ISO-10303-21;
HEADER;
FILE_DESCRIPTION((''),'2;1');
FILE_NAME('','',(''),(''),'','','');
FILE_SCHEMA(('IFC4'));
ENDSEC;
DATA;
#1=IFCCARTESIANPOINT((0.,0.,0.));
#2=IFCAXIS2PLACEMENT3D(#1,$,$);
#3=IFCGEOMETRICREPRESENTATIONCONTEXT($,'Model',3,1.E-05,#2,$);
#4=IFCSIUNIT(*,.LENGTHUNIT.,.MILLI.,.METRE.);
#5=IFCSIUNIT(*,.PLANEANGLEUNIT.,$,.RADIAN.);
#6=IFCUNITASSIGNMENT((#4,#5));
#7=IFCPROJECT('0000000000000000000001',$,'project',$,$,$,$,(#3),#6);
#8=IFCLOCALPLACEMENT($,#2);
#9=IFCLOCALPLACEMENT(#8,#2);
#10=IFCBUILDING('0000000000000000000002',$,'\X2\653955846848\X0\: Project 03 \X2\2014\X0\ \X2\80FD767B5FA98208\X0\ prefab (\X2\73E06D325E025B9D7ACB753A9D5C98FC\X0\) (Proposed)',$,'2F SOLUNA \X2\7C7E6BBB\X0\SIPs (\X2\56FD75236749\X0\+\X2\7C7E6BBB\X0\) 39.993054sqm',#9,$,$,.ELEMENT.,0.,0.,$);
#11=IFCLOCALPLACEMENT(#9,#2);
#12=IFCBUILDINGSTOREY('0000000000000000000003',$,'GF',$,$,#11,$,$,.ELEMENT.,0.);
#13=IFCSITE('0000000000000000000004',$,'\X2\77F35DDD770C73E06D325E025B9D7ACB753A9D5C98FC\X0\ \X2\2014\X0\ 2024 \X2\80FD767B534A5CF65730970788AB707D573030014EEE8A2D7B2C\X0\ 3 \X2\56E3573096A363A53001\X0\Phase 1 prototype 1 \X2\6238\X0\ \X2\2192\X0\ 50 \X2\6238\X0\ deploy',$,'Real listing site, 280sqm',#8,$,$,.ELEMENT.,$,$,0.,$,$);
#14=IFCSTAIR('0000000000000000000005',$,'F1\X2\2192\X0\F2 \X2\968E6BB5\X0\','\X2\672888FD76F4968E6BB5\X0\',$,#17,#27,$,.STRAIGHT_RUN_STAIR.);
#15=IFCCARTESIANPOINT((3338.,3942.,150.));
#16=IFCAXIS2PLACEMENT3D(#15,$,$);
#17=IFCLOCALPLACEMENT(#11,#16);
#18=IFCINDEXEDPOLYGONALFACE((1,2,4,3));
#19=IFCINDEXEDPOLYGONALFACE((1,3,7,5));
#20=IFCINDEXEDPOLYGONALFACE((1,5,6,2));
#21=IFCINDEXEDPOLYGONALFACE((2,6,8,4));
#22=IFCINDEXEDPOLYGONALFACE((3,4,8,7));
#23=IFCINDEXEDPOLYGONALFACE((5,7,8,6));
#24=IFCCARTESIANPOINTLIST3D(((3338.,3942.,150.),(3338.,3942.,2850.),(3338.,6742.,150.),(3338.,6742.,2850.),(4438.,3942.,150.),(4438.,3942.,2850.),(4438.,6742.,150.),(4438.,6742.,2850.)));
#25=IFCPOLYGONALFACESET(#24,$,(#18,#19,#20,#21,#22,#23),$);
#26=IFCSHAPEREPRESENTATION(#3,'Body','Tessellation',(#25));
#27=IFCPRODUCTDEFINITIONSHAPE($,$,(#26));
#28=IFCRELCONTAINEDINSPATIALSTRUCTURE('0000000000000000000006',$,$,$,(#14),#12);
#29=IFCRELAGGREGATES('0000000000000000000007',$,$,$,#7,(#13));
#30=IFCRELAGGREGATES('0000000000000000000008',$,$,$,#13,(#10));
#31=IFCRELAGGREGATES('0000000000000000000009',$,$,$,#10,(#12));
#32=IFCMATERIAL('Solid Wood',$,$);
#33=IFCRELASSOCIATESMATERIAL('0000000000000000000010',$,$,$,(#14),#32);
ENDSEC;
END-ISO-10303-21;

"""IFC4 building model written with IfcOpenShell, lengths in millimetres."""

from ifc_helpers import new_model, si_unit, frame, frame_2d, origin, place, context, project, spatial, rectangle, extrude, material, element, save


model = new_model("IFC4")

# Units and contexts
model_context = context("Model", 3, precision=1e-05, world=origin())
ifc_project = project(units=[si_unit("LENGTHUNIT", "METRE", prefix="MILLI"), si_unit("PLANEANGLEUNIT", "RADIAN")], contexts=[model_context])

# Site, building, storey
site_placement = place(None, origin())
site = spatial("IfcSite", under=ifc_project, at=site_placement, Name="石川県珠洲市宝立町鵜飼 — 2024 能登半島地震被災地、仮設第 3 団地隣接、Phase 1 prototype 1 戸 → 50 戸 deploy", ObjectType="Real listing site, 280sqm", CompositionType="ELEMENT", RefElevation=0.0)
building_placement = place(site_placement, origin())
building = spatial("IfcBuilding", under=site, at=building_placement, Name="改善案: Project 03 — 能登復興 prefab (珠洲市宝立町鵜飼) (Proposed)", ObjectType="2F SOLUNA 籾殻SIPs (国産杉+籾殻) 39.993054sqm", CompositionType="ELEMENT", ElevationOfRefHeight=0.0, ElevationOfTerrain=0.0)
storey_placement = place(building_placement, origin())
storey = spatial("IfcBuildingStorey", under=building, at=storey_placement, Name="GF", CompositionType="ELEMENT", Elevation=0.0)

# Stair
ifc_material_1 = material(Name="Solid Wood")
stair_placement = place(storey_placement, frame((3338.0, 3942.0, 150.0)))
element("IfcStair", 1, at=stair_placement, inside=storey, material=ifc_material_1, Name="F1→F2 階段", Description="木製直階段", PredefinedType="STRAIGHT_RUN_STAIR", context=model_context, shape_type="SweptSolid", body=[
    extrude(rectangle(XDim=1100.0, YDim=2800.0, at=frame_2d((550.0, 1400.0))), frame((3338.0, 3942.0, 150.0)), (0.0, 0.0, 1.0), 2700.0),
])

save(model, "model.ifc")
